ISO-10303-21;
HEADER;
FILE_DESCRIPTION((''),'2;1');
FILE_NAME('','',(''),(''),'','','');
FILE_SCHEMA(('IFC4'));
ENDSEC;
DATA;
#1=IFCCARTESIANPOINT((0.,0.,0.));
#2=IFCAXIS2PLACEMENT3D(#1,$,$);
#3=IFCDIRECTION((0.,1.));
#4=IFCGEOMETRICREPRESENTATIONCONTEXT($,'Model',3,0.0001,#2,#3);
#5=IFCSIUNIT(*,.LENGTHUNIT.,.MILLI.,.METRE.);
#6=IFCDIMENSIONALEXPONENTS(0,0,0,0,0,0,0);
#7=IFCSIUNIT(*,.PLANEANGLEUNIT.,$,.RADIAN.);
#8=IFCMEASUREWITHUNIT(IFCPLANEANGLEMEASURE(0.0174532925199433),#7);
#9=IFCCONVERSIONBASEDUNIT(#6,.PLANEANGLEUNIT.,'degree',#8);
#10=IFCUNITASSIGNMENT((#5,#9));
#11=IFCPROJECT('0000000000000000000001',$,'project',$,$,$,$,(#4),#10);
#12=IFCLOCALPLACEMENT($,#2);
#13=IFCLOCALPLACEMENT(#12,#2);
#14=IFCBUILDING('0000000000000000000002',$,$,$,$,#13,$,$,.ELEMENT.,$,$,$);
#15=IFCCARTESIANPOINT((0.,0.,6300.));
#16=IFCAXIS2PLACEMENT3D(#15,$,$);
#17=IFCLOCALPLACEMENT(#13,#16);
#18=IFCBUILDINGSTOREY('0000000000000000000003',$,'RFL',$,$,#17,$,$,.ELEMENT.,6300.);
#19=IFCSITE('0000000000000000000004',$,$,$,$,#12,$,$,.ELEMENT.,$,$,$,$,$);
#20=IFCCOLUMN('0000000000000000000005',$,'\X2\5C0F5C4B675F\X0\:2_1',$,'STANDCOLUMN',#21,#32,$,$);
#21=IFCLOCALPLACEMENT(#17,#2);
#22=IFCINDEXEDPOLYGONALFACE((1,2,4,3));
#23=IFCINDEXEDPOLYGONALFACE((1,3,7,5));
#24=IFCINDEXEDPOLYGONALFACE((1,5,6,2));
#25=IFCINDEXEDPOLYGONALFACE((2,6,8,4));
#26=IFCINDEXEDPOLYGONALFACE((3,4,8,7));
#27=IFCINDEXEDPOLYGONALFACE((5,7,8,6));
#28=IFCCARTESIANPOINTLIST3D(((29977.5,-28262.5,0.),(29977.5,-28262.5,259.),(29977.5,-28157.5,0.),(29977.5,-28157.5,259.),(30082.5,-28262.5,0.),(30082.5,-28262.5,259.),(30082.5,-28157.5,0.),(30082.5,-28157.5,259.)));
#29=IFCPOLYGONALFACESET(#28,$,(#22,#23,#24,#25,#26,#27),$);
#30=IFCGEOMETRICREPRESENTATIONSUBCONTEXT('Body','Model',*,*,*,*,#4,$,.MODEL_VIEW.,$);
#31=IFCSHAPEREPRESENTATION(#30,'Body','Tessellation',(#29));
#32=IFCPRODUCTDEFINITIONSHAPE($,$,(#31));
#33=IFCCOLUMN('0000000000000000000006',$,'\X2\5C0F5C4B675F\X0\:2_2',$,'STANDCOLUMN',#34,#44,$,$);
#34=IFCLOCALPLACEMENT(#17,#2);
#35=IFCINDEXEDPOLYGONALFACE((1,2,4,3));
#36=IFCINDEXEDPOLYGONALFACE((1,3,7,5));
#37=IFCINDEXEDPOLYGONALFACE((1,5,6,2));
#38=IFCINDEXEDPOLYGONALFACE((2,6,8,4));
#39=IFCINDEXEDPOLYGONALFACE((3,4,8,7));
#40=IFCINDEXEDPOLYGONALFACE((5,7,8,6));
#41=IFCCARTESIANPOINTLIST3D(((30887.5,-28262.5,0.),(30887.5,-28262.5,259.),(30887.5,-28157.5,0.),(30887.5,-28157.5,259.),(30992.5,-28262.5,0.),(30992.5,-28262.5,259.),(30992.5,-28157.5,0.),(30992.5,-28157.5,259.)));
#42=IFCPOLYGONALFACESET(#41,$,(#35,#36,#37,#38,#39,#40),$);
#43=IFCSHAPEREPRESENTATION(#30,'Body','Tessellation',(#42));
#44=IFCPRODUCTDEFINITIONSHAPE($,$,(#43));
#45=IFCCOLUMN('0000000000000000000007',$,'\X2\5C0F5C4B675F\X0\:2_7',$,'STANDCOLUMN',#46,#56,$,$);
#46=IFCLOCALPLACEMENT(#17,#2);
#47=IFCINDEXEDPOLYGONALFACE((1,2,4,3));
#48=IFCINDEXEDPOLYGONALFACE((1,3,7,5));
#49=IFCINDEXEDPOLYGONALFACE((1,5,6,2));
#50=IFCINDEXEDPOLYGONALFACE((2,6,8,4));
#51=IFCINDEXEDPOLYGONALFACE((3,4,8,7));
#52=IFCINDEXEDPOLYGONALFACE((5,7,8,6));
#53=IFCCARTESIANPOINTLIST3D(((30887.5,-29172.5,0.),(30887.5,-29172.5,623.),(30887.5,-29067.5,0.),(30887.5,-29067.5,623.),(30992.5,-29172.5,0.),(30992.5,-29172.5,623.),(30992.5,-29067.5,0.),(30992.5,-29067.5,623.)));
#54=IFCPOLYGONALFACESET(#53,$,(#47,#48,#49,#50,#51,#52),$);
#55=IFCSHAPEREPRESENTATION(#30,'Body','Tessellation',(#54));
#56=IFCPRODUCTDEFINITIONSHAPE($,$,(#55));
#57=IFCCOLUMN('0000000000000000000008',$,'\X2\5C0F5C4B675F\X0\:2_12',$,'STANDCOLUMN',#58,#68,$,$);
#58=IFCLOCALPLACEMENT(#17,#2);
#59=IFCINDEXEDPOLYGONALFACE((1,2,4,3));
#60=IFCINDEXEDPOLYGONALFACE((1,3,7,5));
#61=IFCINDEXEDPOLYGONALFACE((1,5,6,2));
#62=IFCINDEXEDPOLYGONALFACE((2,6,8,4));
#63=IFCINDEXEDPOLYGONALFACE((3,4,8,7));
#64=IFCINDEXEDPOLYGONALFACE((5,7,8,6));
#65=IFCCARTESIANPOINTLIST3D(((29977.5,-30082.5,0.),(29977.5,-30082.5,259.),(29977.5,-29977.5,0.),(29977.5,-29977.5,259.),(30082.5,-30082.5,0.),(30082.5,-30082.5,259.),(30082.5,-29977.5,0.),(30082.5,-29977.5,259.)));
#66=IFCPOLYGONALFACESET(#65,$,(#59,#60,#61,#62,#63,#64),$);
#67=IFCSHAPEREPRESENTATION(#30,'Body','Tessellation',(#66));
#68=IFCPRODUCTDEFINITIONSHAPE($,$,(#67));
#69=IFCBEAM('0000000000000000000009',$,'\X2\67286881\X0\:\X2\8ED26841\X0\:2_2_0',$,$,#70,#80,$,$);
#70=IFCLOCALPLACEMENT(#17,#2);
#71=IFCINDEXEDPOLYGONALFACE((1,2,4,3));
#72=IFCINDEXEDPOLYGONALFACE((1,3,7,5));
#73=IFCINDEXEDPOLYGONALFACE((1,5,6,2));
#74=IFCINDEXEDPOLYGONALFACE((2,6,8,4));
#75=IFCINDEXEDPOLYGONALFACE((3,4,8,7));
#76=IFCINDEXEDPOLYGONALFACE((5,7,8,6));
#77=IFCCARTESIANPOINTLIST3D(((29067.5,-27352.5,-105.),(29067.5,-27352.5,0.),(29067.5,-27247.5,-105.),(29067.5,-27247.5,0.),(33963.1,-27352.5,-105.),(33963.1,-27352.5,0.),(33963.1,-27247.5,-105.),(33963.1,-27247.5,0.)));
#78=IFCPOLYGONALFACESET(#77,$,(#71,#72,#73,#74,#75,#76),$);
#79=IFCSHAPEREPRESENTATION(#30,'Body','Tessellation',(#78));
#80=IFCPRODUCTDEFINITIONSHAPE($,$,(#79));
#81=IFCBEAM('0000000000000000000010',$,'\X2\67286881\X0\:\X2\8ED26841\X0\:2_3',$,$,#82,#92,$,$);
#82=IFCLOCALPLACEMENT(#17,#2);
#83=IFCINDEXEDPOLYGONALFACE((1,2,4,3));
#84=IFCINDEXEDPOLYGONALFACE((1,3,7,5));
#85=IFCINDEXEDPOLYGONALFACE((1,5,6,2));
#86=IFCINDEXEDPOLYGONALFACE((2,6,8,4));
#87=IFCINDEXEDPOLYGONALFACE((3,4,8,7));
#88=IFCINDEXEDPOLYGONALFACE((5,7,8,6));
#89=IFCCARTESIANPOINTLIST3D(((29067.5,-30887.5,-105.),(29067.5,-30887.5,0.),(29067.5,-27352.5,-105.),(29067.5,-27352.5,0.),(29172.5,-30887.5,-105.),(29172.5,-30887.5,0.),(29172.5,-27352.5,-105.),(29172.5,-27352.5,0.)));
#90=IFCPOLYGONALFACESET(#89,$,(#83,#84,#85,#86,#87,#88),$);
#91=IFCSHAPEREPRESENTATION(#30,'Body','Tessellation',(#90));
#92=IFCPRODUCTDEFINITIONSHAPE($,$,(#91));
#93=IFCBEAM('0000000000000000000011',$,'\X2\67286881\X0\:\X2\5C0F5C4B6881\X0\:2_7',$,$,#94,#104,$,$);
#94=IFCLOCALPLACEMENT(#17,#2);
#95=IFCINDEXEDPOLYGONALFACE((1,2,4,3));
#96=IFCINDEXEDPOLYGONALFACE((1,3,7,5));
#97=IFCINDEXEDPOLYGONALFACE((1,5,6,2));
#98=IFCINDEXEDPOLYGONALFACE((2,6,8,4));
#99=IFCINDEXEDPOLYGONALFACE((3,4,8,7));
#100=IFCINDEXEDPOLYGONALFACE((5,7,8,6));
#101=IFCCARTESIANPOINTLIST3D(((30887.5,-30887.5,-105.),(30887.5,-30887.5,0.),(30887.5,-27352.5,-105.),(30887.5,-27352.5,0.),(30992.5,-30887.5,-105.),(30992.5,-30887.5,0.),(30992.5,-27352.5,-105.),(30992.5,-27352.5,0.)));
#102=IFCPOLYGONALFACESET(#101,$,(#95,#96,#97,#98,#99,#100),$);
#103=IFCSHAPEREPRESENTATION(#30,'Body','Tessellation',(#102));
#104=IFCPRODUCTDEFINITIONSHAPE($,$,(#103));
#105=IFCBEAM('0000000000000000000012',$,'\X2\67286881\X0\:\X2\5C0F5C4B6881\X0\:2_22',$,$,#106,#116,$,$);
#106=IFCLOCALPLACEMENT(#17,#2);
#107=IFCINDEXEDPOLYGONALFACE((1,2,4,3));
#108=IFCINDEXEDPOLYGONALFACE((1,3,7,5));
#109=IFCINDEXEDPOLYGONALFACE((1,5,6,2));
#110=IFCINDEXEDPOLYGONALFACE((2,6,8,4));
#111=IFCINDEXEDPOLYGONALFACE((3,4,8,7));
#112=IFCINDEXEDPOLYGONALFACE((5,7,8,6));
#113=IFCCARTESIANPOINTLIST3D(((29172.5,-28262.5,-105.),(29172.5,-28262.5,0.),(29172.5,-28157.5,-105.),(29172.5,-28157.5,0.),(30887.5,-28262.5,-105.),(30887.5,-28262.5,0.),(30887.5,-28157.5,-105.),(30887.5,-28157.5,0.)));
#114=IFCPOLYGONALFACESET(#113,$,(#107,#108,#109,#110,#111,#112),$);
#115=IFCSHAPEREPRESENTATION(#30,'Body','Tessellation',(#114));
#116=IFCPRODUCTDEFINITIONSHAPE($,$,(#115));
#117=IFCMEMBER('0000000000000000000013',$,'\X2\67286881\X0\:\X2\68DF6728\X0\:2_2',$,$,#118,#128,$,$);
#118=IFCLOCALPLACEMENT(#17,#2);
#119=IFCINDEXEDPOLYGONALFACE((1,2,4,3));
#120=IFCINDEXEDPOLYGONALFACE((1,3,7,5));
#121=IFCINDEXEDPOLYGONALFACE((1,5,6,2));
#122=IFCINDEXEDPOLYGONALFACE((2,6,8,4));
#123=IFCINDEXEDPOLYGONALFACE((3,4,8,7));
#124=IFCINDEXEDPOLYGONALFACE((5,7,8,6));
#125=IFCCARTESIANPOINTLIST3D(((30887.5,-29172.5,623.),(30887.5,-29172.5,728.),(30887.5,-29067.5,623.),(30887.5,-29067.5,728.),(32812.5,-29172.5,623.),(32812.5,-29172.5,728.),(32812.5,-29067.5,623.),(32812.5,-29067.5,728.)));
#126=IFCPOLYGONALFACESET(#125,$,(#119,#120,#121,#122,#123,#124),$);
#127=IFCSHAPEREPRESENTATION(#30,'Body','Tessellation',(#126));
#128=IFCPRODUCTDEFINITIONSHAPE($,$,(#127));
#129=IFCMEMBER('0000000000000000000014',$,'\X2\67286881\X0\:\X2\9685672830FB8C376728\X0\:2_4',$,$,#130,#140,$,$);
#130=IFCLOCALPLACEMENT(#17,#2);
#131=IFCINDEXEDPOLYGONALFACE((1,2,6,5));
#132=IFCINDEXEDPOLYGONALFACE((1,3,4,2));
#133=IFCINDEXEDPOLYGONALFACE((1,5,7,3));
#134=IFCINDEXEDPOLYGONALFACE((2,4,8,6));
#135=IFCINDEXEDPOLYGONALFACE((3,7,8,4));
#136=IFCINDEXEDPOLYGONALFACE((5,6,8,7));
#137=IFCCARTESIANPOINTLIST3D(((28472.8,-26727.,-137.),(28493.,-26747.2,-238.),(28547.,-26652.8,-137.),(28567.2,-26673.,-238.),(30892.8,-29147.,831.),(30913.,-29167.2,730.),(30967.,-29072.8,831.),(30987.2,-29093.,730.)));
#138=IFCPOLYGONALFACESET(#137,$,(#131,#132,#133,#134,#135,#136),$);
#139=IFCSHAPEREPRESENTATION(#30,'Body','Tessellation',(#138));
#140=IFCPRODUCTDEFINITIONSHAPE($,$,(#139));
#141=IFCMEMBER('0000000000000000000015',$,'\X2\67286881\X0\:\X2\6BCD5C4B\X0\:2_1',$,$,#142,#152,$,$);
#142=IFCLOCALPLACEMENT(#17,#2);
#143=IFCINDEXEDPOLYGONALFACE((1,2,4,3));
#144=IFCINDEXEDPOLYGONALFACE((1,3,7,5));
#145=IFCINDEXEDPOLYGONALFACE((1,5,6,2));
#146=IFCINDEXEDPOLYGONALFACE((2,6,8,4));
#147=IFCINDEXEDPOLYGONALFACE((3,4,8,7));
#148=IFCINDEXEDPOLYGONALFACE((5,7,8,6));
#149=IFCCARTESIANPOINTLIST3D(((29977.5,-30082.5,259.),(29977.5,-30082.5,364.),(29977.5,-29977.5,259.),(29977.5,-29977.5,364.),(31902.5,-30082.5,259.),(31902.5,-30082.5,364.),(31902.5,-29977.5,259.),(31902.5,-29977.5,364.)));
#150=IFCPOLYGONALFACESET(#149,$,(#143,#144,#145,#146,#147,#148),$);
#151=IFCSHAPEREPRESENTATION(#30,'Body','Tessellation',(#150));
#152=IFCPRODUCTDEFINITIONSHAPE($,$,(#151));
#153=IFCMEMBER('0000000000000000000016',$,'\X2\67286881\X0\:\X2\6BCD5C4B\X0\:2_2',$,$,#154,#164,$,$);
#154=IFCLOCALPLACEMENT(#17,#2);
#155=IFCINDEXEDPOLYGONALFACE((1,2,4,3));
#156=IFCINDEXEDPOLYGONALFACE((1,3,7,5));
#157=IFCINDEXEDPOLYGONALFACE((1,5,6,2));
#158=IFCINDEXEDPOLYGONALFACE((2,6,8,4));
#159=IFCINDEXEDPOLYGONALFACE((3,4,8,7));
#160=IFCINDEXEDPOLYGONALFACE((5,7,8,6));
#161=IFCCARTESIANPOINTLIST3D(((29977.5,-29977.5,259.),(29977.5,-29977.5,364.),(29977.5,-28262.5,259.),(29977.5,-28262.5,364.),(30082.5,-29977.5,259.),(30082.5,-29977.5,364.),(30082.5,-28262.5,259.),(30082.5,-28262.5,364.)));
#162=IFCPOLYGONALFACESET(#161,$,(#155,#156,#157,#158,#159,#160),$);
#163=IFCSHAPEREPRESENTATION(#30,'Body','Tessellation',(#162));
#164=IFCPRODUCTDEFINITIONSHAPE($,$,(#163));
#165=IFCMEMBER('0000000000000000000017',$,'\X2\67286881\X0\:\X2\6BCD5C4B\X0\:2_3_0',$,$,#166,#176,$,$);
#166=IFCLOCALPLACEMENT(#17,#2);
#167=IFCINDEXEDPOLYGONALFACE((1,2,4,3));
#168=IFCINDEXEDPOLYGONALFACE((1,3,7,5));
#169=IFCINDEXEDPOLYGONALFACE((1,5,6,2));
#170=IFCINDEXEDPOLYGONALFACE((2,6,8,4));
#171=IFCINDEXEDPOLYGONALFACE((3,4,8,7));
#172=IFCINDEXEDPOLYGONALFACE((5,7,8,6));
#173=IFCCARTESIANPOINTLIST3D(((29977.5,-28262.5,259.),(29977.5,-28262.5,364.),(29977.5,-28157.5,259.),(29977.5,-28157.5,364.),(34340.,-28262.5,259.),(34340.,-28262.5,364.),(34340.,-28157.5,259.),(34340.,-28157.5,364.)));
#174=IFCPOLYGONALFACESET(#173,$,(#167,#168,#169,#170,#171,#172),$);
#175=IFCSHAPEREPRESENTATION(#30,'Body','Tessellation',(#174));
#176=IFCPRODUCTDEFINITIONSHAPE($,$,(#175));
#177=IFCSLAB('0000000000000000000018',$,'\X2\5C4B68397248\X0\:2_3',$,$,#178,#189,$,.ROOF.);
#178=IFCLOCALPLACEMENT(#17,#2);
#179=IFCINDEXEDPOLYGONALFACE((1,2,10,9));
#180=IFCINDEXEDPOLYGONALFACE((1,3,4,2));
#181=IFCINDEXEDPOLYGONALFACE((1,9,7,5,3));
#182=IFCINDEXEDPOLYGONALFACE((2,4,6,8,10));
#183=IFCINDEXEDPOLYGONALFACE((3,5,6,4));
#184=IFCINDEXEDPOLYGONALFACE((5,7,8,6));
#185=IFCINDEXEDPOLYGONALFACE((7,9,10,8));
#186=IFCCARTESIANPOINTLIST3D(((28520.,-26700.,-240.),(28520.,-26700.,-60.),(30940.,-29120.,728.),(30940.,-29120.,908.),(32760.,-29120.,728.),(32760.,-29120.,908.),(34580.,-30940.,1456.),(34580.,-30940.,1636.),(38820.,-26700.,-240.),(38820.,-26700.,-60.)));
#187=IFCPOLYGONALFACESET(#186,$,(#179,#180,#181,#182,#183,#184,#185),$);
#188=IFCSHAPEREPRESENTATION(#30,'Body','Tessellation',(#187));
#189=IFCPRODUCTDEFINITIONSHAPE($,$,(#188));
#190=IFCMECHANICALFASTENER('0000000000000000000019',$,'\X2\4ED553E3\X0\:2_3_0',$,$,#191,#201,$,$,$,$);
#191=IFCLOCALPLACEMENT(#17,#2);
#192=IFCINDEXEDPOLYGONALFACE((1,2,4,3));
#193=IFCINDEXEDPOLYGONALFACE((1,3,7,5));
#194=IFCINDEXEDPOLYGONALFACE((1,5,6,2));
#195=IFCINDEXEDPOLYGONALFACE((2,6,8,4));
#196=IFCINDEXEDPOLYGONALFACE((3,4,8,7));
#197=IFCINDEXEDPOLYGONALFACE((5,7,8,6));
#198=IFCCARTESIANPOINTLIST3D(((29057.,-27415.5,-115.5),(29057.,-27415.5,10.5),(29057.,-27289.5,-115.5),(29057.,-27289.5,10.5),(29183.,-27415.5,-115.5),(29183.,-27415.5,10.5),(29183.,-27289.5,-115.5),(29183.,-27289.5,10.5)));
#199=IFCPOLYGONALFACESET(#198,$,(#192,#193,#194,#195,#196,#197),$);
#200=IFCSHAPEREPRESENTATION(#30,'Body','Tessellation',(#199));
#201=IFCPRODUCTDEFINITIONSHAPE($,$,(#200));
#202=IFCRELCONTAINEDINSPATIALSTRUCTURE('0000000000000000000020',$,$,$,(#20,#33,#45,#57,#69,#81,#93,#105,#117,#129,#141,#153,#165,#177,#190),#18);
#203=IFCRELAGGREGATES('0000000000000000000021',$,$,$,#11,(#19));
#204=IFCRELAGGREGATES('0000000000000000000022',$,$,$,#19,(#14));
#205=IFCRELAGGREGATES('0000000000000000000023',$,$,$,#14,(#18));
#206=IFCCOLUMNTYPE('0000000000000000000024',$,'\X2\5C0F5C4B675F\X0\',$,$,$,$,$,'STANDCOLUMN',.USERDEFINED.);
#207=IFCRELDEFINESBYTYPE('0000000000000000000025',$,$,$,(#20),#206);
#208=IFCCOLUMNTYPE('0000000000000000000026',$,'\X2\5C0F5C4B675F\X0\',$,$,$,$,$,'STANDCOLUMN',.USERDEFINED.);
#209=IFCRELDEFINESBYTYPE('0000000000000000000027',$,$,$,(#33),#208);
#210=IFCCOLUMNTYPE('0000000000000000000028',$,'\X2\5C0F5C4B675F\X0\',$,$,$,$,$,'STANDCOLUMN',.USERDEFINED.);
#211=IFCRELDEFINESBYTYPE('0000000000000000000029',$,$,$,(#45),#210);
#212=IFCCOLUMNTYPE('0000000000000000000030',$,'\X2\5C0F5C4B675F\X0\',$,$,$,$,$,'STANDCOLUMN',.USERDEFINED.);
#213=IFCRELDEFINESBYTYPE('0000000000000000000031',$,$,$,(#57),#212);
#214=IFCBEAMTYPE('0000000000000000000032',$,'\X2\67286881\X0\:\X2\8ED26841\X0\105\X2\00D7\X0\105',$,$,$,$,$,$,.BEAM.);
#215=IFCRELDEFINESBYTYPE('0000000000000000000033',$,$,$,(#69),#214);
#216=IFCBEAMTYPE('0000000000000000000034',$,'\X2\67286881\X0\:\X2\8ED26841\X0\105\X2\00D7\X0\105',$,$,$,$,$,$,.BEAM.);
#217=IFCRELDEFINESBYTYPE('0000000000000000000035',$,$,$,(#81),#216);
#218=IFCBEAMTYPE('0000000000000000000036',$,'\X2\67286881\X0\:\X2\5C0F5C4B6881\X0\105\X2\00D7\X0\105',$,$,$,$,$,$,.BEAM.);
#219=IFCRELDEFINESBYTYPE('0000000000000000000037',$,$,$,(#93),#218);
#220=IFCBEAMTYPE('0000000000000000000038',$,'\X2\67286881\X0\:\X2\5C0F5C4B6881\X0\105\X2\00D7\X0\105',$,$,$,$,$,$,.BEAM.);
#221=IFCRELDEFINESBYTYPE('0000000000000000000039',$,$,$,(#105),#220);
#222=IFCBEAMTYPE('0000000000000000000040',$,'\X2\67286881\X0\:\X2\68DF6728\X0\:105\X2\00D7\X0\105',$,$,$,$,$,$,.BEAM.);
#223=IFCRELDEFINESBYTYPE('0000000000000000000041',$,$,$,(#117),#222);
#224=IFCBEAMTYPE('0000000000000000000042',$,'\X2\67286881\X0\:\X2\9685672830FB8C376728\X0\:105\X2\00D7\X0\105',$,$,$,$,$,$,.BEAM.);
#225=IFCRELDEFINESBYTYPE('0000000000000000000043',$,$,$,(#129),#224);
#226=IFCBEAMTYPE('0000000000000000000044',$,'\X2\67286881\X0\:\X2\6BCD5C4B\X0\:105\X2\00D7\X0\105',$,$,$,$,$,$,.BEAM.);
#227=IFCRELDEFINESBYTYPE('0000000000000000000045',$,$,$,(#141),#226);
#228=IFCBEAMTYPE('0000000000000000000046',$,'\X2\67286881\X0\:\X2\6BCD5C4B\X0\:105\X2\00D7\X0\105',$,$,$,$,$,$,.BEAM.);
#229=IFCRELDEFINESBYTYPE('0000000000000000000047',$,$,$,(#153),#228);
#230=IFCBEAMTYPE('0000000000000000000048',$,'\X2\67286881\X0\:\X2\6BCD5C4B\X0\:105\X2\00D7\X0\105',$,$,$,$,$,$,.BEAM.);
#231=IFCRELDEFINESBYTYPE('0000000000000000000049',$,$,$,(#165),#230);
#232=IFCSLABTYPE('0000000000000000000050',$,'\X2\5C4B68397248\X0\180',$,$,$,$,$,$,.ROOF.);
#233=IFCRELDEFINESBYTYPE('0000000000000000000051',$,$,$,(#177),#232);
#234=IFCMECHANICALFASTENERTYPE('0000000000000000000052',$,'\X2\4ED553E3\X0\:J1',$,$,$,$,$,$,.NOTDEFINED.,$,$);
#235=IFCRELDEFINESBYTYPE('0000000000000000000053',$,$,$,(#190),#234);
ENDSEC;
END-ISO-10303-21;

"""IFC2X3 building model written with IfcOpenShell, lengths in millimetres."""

from ifc_helpers import new_model, entity, si_unit, converted_unit, direction, frame, origin, origin_with_axes, origin_2d, place, context, subcontext, project, spatial, polyline, rectangle, outline, extrude, type_object, element, save


model = new_model("IFC2X3")

# Units and contexts
model_context = context("Model", 3, precision=0.0001, world=origin(), true_north=direction((0.0, 1.0)))
body_context = subcontext(model_context, "Body", "Model", "MODEL_VIEW")
ifc_project = project(units=[si_unit("LENGTHUNIT", "METRE", prefix="MILLI"), converted_unit("PLANEANGLEUNIT", "degree", entity("IfcPlaneAngleMeasure", 0.0174532925199433), si_unit("PLANEANGLEUNIT", "RADIAN"), dimensions=[0, 0, 0, 0, 0, 0, 0])], contexts=[model_context])

# Site, building, storey
site_placement = place(None, origin())
site = spatial("IfcSite", under=ifc_project, at=site_placement, CompositionType="ELEMENT")
building_placement = place(site_placement, origin())
building = spatial("IfcBuilding", under=site, at=building_placement, CompositionType="ELEMENT")
storey_placement = place(building_placement, frame((0.0, 0.0, 6300.0)))
storey = spatial("IfcBuildingStorey", under=building, at=storey_placement, Name="RFL", CompositionType="ELEMENT", Elevation=6300.0)

# Columns
column_type_1 = type_object("IfcColumnType", Name="小屋束", ElementType="STANDCOLUMN", PredefinedType="USERDEFINED")
column_1_placement = place(storey_placement, frame((30030.0, -28210.0, 0.0)))
element("IfcColumn", 1, at=column_1_placement, inside=storey, type_object=column_type_1, Name="小屋束:2_1", ObjectType="STANDCOLUMN", context=body_context, shape_type="SweptSolid", body=[
    extrude(rectangle(XDim=105.0, YDim=105.0, at=origin_2d()), origin_with_axes(), (0.0, 0.0, 1.0), 259.0),
])
column_type_2 = type_object("IfcColumnType", Name="小屋束", ElementType="STANDCOLUMN", PredefinedType="USERDEFINED")
column_2_placement = place(storey_placement, frame((30940.0, -28210.0, 0.0)))
element("IfcColumn", 2, at=column_2_placement, inside=storey, type_object=column_type_2, Name="小屋束:2_2", ObjectType="STANDCOLUMN", context=body_context, shape_type="SweptSolid", body=[
    extrude(rectangle(XDim=105.0, YDim=105.0, at=origin_2d()), origin_with_axes(), (0.0, 0.0, 1.0), 259.0),
])
column_type_3 = type_object("IfcColumnType", Name="小屋束", ElementType="STANDCOLUMN", PredefinedType="USERDEFINED")
column_3_placement = place(storey_placement, frame((30940.0, -29120.0, 0.0)))
element("IfcColumn", 3, at=column_3_placement, inside=storey, type_object=column_type_3, Name="小屋束:2_7", ObjectType="STANDCOLUMN", context=body_context, shape_type="SweptSolid", body=[
    extrude(rectangle(XDim=105.0, YDim=105.0, at=origin_2d()), origin_with_axes(), (0.0, 0.0, 1.0), 623.0),
])
column_type_4 = type_object("IfcColumnType", Name="小屋束", ElementType="STANDCOLUMN", PredefinedType="USERDEFINED")
column_4_placement = place(storey_placement, frame((30030.0, -30030.0, 0.0)))
element("IfcColumn", 4, at=column_4_placement, inside=storey, type_object=column_type_4, Name="小屋束:2_12", ObjectType="STANDCOLUMN", context=body_context, shape_type="SweptSolid", body=[
    extrude(rectangle(XDim=105.0, YDim=105.0, at=origin_2d()), origin_with_axes(), (0.0, 0.0, 1.0), 259.0),
])

# Beams
beam_type_1 = type_object("IfcBeamType", Name="木梁:軒桁105×105", PredefinedType="BEAM")
beam_1_placement = place(storey_placement, frame((29067.5, -27300.0, -52.5), z_axis=(1.0, 0.0, 0.0), x_axis=(0.0, 1.0, 0.0)))
element("IfcBeam", 5, at=beam_1_placement, inside=storey, type_object=beam_type_1, Name="木梁:軒桁:2_2_0", context=body_context, shape_type="SweptSolid", body=[
    extrude(rectangle(XDim=105.0, YDim=105.0, at=origin_2d()), origin_with_axes(), (0.0, 0.0, 1.0), 4895.6),
])
beam_type_2 = type_object("IfcBeamType", Name="木梁:軒桁105×105", PredefinedType="BEAM")
beam_2_placement = place(storey_placement, frame((29120.0, -27352.5, -52.5), z_axis=(0.0, -1.0, 0.0), x_axis=(1.0, 0.0, 0.0)))
element("IfcBeam", 6, at=beam_2_placement, inside=storey, type_object=beam_type_2, Name="木梁:軒桁:2_3", context=body_context, shape_type="SweptSolid", body=[
    extrude(rectangle(XDim=105.0, YDim=105.0, at=origin_2d()), origin_with_axes(), (0.0, 0.0, 1.0), 3535.0),
])
beam_type_3 = type_object("IfcBeamType", Name="木梁:小屋梁105×105", PredefinedType="BEAM")
beam_3_placement = place(storey_placement, frame((30940.0, -27352.5, -52.5), z_axis=(0.0, -1.0, 0.0), x_axis=(1.0, 0.0, 0.0)))
element("IfcBeam", 7, at=beam_3_placement, inside=storey, type_object=beam_type_3, Name="木梁:小屋梁:2_7", context=body_context, shape_type="SweptSolid", body=[
    extrude(rectangle(XDim=105.0, YDim=105.0, at=origin_2d()), origin_with_axes(), (0.0, 0.0, 1.0), 3535.0),
])
beam_type_4 = type_object("IfcBeamType", Name="木梁:小屋梁105×105", PredefinedType="BEAM")
beam_4_placement = place(storey_placement, frame((29172.5, -28210.0, -52.5), z_axis=(1.0, 0.0, 0.0), x_axis=(0.0, 1.0, 0.0)))
element("IfcBeam", 8, at=beam_4_placement, inside=storey, type_object=beam_type_4, Name="木梁:小屋梁:2_22", context=body_context, shape_type="SweptSolid", body=[
    extrude(rectangle(XDim=105.0, YDim=105.0, at=origin_2d()), origin_with_axes(), (0.0, 0.0, 1.0), 1715.0),
])

# Members
beam_type_5 = type_object("IfcBeamType", Name="木梁:棟木:105×105", PredefinedType="BEAM")
member_1_placement = place(storey_placement, frame((30887.5, -29120.0, 675.5), z_axis=(1.0, 0.0, 0.0), x_axis=(0.0, -1.0, 0.0)))
element("IfcMember", 9, at=member_1_placement, inside=storey, type_object=beam_type_5, Name="木梁:棟木:2_2", context=body_context, shape_type="SweptSolid", body=[
    extrude(rectangle(XDim=105.0, YDim=105.0, at=origin_2d()), origin_with_axes(), (0.0, 0.0, 1.0), 1925.0),
])
beam_type_6 = type_object("IfcBeamType", Name="木梁:隅木・谷木:105×105", PredefinedType="BEAM")
member_2_placement = place(storey_placement, frame((28520.0, -26700.0, -187.5), z_axis=(0.680414, -0.680414, 0.272166), x_axis=(-0.707107, -0.707107, 0.0)))
element("IfcMember", 10, at=member_2_placement, inside=storey, type_object=beam_type_6, Name="木梁:隅木・谷木:2_4", context=body_context, shape_type="SweptSolid", body=[
    extrude(rectangle(XDim=105.0, YDim=105.0, at=origin_2d()), origin_with_axes(), (0.0, 0.0, 1.0), 3556.7),
])
beam_type_7 = type_object("IfcBeamType", Name="木梁:母屋:105×105", PredefinedType="BEAM")
member_3_placement = place(storey_placement, frame((29977.5, -30030.0, 311.5), z_axis=(1.0, 0.0, 0.0), x_axis=(0.0, -1.0, 0.0)))
element("IfcMember", 11, at=member_3_placement, inside=storey, type_object=beam_type_7, Name="木梁:母屋:2_1", context=body_context, shape_type="SweptSolid", body=[
    extrude(rectangle(XDim=105.0, YDim=105.0, at=origin_2d()), origin_with_axes(), (0.0, 0.0, 1.0), 1925.0),
])
beam_type_8 = type_object("IfcBeamType", Name="木梁:母屋:105×105", PredefinedType="BEAM")
member_4_placement = place(storey_placement, frame((30030.0, -28262.5, 311.5), z_axis=(0.0, -1.0, 0.0), x_axis=(-1.0, 0.0, 0.0)))
element("IfcMember", 12, at=member_4_placement, inside=storey, type_object=beam_type_8, Name="木梁:母屋:2_2", context=body_context, shape_type="SweptSolid", body=[
    extrude(rectangle(XDim=105.0, YDim=105.0, at=origin_2d()), origin_with_axes(), (0.0, 0.0, 1.0), 1715.0),
])
beam_type_9 = type_object("IfcBeamType", Name="木梁:母屋:105×105", PredefinedType="BEAM")
member_5_placement = place(storey_placement, frame((29977.5, -28210.0, 311.5), z_axis=(1.0, 0.0, 0.0), x_axis=(0.0, -1.0, 0.0)))
element("IfcMember", 13, at=member_5_placement, inside=storey, type_object=beam_type_9, Name="木梁:母屋:2_3_0", context=body_context, shape_type="SweptSolid", body=[
    extrude(rectangle(XDim=105.0, YDim=105.0, at=origin_2d()), origin_with_axes(), (0.0, 0.0, 1.0), 4362.5),
])

# Slab
slab_type = type_object("IfcSlabType", Name="屋根版180", PredefinedType="ROOF")
slab_placement = place(storey_placement, frame((28520.0, -26700.0, -240.0), z_axis=(0.0, -0.371391, -0.928477), x_axis=(1.0, 0.0, 0.0)))
element("IfcSlab", 14, at=slab_placement, inside=storey, type_object=slab_type, Name="屋根版:2_3", PredefinedType="ROOF", context=body_context, shape_type="SweptSolid", body=[
    extrude(outline(polyline([(0.0, 0.0, 0.0), (10300.0, 0.0, 0.0), (6060.0, 4566.6, 0.0), (4240.0, 2606.4, 0.0), (2420.0, 2606.4, 0.0), (0.0, 0.0, 0.0)])), origin_with_axes(), (0.0, 0.371391, -0.928477), 180.0),
])

# Mechanical fastener
mechanical_fastener_type_1 = type_object("IfcMechanicalFastenerType", Name="仕口:J1")
mechanical_fastener_1_placement = place(storey_placement, frame((29120.0, -27352.5, -115.5)))
element("IfcMechanicalFastener", 15, at=mechanical_fastener_1_placement, inside=storey, type_object=mechanical_fastener_type_1, Name="仕口:2_3_0", context=body_context, shape_type="SweptSolid", body=[
    extrude(rectangle(XDim=126.0, YDim=126.0, at=origin_2d()), origin_with_axes(), (0.0, 0.0, 1.0), 126.0),
])

save(model, "model.ifc")
